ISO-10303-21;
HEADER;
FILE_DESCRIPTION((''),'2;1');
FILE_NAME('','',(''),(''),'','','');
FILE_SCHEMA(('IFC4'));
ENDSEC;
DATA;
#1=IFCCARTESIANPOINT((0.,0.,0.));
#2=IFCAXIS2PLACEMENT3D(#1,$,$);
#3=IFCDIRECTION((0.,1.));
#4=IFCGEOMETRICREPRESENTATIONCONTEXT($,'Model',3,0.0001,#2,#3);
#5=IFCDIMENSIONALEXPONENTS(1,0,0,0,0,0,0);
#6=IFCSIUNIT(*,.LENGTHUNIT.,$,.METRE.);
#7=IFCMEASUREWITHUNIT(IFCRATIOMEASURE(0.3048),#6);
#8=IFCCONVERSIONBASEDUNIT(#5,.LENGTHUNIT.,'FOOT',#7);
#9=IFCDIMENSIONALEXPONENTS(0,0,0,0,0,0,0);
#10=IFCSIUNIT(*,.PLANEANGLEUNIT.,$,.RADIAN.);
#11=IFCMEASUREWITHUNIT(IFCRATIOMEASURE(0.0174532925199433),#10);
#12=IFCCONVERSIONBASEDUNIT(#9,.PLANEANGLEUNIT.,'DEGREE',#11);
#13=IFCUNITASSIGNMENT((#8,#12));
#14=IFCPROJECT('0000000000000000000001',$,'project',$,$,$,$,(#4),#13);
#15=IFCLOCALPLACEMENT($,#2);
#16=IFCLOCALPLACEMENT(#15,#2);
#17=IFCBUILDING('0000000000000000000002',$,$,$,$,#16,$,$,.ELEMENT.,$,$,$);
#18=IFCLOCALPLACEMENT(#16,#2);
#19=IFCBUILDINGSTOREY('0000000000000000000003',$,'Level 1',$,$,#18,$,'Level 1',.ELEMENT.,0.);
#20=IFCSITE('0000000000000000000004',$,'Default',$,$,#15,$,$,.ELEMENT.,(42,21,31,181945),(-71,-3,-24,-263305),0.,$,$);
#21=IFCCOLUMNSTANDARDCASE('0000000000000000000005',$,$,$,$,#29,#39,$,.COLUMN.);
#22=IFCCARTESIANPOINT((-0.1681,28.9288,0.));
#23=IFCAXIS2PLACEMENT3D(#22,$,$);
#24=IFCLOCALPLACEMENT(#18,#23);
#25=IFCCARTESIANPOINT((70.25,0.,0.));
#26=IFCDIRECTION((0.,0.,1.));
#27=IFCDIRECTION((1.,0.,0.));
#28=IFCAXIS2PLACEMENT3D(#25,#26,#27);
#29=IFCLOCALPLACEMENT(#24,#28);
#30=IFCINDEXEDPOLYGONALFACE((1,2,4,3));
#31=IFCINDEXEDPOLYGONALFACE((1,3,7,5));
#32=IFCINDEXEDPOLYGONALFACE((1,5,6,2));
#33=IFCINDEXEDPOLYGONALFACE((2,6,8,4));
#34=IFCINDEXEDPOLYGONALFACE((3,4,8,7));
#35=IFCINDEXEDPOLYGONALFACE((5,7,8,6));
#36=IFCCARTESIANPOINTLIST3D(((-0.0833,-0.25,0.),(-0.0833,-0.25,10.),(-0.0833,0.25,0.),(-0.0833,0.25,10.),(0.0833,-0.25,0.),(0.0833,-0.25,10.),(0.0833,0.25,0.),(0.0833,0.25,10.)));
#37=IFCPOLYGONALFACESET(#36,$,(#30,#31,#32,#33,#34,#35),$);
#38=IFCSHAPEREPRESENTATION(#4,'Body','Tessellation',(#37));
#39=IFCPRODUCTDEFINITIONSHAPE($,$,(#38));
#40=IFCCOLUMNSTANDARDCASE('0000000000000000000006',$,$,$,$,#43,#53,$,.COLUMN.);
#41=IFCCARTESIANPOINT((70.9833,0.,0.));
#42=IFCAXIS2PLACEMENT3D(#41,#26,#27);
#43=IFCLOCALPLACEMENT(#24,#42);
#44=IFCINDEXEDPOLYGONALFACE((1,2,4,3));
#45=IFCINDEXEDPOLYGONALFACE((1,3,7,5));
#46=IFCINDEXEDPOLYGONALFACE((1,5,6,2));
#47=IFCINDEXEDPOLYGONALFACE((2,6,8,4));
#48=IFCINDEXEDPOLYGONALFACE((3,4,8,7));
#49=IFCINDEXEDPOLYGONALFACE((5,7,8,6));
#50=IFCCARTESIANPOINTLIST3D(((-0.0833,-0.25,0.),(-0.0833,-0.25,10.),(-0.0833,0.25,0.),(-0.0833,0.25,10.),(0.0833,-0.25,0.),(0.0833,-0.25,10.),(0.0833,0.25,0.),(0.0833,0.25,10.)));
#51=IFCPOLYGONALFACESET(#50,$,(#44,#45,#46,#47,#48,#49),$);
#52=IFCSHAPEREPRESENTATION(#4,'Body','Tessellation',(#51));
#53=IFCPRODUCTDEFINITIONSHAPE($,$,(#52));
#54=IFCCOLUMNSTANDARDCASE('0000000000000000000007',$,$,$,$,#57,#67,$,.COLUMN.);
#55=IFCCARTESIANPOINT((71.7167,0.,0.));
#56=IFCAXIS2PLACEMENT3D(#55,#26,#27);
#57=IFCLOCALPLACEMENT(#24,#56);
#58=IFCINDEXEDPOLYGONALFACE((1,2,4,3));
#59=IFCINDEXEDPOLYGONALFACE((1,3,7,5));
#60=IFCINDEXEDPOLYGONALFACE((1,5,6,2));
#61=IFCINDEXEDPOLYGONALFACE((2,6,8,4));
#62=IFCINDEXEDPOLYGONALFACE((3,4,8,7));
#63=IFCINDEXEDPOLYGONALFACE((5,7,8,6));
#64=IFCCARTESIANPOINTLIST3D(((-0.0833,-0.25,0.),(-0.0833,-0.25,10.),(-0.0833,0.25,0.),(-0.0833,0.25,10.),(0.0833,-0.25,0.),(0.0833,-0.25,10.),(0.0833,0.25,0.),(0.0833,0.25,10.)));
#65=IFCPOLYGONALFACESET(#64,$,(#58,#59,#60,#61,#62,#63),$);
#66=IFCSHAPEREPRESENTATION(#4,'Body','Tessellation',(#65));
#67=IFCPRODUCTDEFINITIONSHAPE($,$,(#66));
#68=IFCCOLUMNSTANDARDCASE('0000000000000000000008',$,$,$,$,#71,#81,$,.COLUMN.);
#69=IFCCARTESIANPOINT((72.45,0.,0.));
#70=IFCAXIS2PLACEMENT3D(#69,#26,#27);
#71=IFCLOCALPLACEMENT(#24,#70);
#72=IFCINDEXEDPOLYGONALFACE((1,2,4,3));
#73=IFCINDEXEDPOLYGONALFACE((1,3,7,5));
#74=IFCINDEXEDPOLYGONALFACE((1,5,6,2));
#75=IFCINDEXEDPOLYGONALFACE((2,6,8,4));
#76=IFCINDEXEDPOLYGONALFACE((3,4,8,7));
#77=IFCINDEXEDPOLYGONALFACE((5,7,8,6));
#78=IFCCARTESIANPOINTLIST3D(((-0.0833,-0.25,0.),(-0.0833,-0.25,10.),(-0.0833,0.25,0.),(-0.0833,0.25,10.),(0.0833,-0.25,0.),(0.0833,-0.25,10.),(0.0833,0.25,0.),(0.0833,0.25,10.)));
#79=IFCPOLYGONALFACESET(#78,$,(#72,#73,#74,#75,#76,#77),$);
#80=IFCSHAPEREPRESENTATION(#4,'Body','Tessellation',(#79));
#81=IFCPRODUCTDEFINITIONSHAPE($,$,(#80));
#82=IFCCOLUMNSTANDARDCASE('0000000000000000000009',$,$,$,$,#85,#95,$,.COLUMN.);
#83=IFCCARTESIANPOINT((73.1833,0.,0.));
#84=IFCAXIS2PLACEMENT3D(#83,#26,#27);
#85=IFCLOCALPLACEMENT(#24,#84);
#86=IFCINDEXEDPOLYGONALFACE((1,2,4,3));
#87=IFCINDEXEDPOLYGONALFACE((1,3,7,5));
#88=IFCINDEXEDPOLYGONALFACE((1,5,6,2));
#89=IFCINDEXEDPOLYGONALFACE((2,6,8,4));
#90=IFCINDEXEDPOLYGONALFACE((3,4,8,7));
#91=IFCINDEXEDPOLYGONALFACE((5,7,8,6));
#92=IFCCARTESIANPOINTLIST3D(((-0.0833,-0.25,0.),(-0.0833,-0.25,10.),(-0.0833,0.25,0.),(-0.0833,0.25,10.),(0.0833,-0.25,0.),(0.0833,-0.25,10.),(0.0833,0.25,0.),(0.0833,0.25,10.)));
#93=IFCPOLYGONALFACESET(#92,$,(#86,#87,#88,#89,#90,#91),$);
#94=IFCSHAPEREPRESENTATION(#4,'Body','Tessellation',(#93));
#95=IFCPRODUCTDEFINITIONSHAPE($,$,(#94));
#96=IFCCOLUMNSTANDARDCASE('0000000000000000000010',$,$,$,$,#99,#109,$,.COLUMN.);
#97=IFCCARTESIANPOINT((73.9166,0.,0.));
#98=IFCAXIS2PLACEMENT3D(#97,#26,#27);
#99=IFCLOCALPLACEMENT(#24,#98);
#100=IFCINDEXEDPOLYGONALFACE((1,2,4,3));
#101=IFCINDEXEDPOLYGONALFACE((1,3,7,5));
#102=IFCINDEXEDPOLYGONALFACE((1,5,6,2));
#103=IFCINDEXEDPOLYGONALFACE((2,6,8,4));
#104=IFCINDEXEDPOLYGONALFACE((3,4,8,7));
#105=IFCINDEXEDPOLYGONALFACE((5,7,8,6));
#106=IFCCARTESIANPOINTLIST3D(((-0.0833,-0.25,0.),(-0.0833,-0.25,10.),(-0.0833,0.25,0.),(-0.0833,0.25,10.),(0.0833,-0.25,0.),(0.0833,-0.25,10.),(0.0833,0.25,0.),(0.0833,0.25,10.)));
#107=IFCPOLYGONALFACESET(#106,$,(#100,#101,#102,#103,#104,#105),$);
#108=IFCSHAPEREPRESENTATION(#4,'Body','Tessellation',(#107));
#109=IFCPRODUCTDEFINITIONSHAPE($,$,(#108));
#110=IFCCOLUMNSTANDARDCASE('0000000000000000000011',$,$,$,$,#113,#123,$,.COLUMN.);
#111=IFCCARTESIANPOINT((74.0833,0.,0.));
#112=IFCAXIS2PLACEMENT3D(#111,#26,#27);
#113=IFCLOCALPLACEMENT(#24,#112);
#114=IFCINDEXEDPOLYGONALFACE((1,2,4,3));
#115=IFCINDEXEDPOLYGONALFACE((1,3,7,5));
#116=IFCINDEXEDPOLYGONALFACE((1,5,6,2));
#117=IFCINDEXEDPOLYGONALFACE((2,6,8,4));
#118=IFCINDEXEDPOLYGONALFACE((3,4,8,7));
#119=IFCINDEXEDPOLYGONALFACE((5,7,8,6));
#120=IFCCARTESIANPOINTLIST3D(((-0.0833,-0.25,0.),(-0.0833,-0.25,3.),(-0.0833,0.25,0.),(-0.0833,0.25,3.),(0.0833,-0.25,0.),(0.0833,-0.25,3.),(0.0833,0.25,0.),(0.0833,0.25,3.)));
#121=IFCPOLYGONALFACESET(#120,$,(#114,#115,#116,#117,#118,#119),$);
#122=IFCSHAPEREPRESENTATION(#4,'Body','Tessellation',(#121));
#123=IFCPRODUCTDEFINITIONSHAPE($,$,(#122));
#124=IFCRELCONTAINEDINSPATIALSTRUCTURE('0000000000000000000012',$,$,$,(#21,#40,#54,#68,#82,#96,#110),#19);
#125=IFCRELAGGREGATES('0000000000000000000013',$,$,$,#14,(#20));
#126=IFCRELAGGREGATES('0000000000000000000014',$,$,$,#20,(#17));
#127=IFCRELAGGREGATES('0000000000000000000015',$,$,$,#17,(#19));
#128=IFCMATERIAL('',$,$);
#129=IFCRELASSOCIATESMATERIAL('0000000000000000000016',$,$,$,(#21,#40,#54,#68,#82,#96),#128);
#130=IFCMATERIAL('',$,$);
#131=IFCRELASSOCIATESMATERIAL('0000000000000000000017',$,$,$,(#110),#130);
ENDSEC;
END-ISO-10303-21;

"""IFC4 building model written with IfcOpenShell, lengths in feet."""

from ifc_helpers import new_model, entity, si_unit, converted_unit, direction, frame, origin, place, context, project, spatial, rectangle, extrude, material, element, save


model = new_model("IFC4")

# Units and contexts
model_context = context("Model", 3, precision=0.0001, world=origin(), true_north=direction((0.0, 1.0)))
ifc_project = project(units=[converted_unit("LENGTHUNIT", "FOOT", entity("IfcRatioMeasure", 0.3048), si_unit("LENGTHUNIT", "METRE"), dimensions=[1, 0, 0, 0, 0, 0, 0]), converted_unit("PLANEANGLEUNIT", "DEGREE", entity("IfcRatioMeasure", 0.0174532925199433), si_unit("PLANEANGLEUNIT", "RADIAN"), dimensions=[0, 0, 0, 0, 0, 0, 0])], contexts=[model_context])

# Site, building, storey
site_placement = place(None, origin())
site = spatial("IfcSite", under=ifc_project, at=site_placement, Name="Default", CompositionType="ELEMENT", RefLatitude=(42, 21, 31, 181945), RefLongitude=(-71, -3, -24, -263305), RefElevation=0.0)
building_placement = place(site_placement, origin())
building = spatial("IfcBuilding", under=site, at=building_placement, CompositionType="ELEMENT")
storey_placement = place(building_placement, origin())
storey = spatial("IfcBuildingStorey", under=building, at=storey_placement, Name="Level 1", LongName="Level 1", CompositionType="ELEMENT", Elevation=0.0)

# Columns
ifc_material_1 = material(Name="")
placement = place(storey_placement, frame((-0.1681, 28.9288, 0.0)))
for number, where, z_axis, x_axis in (
    (1, (70.25, 0.0, 0.0), (0.0, 0.0, 1.0), (1.0, 0.0, 0.0)),
    (2, (70.9833, 0.0, 0.0), (0.0, 0.0, 1.0), (1.0, 0.0, 0.0)),
    (3, (71.7167, 0.0, 0.0), (0.0, 0.0, 1.0), (1.0, 0.0, 0.0)),
    (4, (72.45, 0.0, 0.0), (0.0, 0.0, 1.0), (1.0, 0.0, 0.0)),
    (5, (73.1833, 0.0, 0.0), (0.0, 0.0, 1.0), (1.0, 0.0, 0.0)),
    (6, (73.9166, 0.0, 0.0), (0.0, 0.0, 1.0), (1.0, 0.0, 0.0)),
):
    element("IfcColumnStandardCase", number, at=place(placement, frame(where, z_axis=z_axis, x_axis=x_axis)), inside=storey, material=ifc_material_1, PredefinedType="COLUMN", context=model_context, shape_type="SweptSolid", body=[
        extrude(rectangle(XDim=0.1667, YDim=0.5), origin(), (0.0, 0.0, 1.0), 10.0),
    ])
ifc_material_2 = material(Name="")
for number, where, z_axis, x_axis in (
    (7, (74.0833, 0.0, 0.0), (0.0, 0.0, 1.0), (1.0, 0.0, 0.0)),
):
    element("IfcColumnStandardCase", number, at=place(placement, frame(where, z_axis=z_axis, x_axis=x_axis)), inside=storey, material=ifc_material_2, PredefinedType="COLUMN", context=model_context, shape_type="SweptSolid", body=[
        extrude(rectangle(XDim=0.1667, YDim=0.5), origin(), (0.0, 0.0, 1.0), 3.0),
    ])

save(model, "model.ifc")
